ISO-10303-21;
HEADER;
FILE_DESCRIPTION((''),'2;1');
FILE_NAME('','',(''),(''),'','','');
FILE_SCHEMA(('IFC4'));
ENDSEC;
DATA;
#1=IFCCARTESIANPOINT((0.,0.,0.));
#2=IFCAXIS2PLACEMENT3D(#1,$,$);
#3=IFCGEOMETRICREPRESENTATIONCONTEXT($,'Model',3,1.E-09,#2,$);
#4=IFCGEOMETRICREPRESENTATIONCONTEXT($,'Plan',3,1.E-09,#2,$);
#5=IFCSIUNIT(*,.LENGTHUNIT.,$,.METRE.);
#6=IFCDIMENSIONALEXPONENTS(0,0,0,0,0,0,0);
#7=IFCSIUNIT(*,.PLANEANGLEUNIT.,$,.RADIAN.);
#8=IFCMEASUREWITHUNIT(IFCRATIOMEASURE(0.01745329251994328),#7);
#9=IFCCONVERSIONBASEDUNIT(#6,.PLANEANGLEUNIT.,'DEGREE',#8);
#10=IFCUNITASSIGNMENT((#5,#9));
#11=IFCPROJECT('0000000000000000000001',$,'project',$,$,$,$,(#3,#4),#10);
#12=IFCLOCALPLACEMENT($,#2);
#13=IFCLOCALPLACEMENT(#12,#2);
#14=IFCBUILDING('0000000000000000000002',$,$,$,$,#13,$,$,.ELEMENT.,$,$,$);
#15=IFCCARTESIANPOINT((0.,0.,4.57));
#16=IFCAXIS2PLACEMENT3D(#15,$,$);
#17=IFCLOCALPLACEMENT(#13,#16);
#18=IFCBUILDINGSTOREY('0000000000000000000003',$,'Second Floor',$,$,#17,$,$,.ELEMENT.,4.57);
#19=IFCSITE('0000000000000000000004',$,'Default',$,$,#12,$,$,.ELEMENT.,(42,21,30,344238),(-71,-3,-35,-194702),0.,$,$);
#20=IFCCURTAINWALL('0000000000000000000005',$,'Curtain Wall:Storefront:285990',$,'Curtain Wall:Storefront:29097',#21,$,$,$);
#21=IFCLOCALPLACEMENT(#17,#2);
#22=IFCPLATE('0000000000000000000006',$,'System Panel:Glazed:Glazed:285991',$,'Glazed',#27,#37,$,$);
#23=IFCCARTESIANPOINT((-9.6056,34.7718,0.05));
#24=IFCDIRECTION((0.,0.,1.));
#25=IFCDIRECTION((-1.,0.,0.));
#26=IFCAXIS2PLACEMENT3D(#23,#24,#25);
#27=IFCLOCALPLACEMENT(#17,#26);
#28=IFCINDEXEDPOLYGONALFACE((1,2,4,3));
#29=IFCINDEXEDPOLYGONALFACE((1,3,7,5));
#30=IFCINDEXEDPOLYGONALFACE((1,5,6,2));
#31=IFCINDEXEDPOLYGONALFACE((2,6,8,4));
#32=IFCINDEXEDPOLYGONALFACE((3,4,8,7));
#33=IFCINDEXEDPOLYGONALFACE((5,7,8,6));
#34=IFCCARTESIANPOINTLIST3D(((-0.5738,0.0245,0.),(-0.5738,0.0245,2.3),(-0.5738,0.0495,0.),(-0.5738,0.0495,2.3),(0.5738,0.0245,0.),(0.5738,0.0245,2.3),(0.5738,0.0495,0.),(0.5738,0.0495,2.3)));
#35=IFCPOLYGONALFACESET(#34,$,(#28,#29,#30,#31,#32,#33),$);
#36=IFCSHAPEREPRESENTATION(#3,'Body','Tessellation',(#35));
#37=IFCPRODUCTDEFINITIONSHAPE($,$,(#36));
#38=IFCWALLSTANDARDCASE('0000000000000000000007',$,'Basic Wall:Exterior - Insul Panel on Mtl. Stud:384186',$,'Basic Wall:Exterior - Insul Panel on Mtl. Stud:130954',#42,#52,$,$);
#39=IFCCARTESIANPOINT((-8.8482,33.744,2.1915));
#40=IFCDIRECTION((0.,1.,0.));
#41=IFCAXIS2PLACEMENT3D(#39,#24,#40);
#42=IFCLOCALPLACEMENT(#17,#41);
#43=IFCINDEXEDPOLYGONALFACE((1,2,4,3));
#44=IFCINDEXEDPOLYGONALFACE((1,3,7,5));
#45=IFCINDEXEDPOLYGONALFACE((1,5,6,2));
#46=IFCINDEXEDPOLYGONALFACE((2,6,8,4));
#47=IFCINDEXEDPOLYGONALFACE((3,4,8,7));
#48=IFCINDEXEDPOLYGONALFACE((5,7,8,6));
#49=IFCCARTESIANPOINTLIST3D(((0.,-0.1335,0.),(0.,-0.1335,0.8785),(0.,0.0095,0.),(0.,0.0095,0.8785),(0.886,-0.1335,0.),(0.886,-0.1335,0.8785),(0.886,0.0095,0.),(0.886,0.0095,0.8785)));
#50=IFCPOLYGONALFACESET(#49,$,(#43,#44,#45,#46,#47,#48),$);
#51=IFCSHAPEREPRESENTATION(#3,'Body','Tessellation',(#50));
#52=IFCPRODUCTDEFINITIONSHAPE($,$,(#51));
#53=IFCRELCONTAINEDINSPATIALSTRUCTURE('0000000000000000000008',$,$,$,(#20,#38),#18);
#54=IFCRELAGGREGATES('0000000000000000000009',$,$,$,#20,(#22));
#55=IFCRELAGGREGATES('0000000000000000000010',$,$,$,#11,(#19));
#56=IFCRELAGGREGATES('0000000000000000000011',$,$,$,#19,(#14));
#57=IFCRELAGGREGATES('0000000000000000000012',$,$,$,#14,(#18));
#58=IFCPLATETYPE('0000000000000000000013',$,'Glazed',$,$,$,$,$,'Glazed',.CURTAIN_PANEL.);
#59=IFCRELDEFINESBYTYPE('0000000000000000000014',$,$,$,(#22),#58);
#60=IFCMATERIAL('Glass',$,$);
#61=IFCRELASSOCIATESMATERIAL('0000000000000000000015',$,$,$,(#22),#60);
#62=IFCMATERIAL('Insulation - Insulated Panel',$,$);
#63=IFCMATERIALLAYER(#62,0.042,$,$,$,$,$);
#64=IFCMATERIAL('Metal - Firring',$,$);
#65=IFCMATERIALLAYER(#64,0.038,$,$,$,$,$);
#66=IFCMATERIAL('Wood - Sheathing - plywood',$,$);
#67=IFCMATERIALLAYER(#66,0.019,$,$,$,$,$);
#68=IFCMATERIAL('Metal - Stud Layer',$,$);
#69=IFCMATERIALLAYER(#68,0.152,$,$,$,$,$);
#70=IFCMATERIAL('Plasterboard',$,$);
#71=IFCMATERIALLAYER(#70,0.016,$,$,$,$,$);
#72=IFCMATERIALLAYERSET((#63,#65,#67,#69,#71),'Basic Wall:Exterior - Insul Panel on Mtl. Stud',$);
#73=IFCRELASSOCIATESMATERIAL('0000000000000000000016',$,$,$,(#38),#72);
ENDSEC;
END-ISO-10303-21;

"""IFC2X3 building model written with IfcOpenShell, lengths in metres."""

from ifc_helpers import new_model, entity, si_unit, converted_unit, frame, frame_2d, origin, origin_2d_with_axis, place, context, project, spatial, polyline, rectangle, extrude, clip, bounded_halfspace, source, transform, mapped, material, layer, layer_set, layer_usage, type_object, type_shapes, element, aggregate, save


model = new_model("IFC2X3")

# Units and contexts
model_context = context("Model", 3, precision=1e-09, world=origin())
plan_context = context("Plan", 3, precision=1e-09, world=origin())
ifc_project = project(units=[si_unit("LENGTHUNIT", "METRE"), converted_unit("PLANEANGLEUNIT", "DEGREE", entity("IfcRatioMeasure", 0.01745329251994328), si_unit("PLANEANGLEUNIT", "RADIAN"), dimensions=[0, 0, 0, 0, 0, 0, 0])], contexts=[model_context, plan_context])

# Site, building, storey
site_placement = place(None, origin())
site = spatial("IfcSite", under=ifc_project, at=site_placement, Name="Default", CompositionType="ELEMENT", RefLatitude=(42, 21, 30, 344238), RefLongitude=(-71, -3, -35, -194702), RefElevation=0.0)
building_placement = place(site_placement, origin())
building = spatial("IfcBuilding", under=site, at=building_placement, CompositionType="ELEMENT")
storey_placement = place(building_placement, frame((0.0, 0.0, 4.57)))
storey = spatial("IfcBuildingStorey", under=building, at=storey_placement, Name="Second Floor", CompositionType="ELEMENT", Elevation=4.57)

# Curtain wall
curtain_wall_1_placement = place(storey_placement, origin())
curtain_wall_1 = element("IfcCurtainWall", 1, at=curtain_wall_1_placement, inside=storey, Name="Curtain Wall:Storefront:285990", ObjectType="Curtain Wall:Storefront:29097")

# Plate
ifc_material_1 = material(Name="Glass")
plate_type_1 = type_object("IfcPlateType", Name="Glazed", ElementType="Glazed", PredefinedType="CURTAIN_PANEL")
shared_shape_1 = source(origin(), model_context, "Body", "SweptSolid", [
    extrude(rectangle(XDim=0.025, YDim=1.1477, at=origin_2d_with_axis()), frame((0.0, 0.037, 0.0), z_axis=(0.0, 0.0, 1.0), x_axis=(0.0, 1.0, 0.0)), (0.0, 0.0, 1.0), 2.3),
])
type_shapes(plate_type_1, [shared_shape_1])
plate_1_placement = place(storey_placement, frame((-9.6056, 34.7718, 0.05), z_axis=(0.0, 0.0, 1.0), x_axis=(-1.0, 0.0, 0.0)))
plate_1 = element("IfcPlate", 2, at=plate_1_placement, type_object=plate_type_1, material=ifc_material_1, Name="System Panel:Glazed:Glazed:285991", ObjectType="Glazed", context=model_context, shape_type="MappedRepresentation", body=[
    mapped(shared_shape_1, transform((0.0, 0.0, 0.0), scale=1.0)),
])
aggregate(curtain_wall_1, [plate_1])

# Shared definitions
ifc_material_2 = material(Name="Plasterboard")
ifc_layer_1 = layer(ifc_material_2, 0.016)
ifc_material_3 = material(Name="Metal - Stud Layer")
ifc_material_4 = material(Name="Insulation - Insulated Panel")
ifc_layer_2 = layer(ifc_material_4, 0.042)
ifc_material_5 = material(Name="Metal - Firring")
ifc_layer_3 = layer(ifc_material_5, 0.038)
ifc_material_6 = material(Name="Wood - Sheathing - plywood")
ifc_layer_4 = layer(ifc_material_6, 0.019)
ifc_layer_5 = layer(ifc_material_3, 0.152)
ifc_layer_set_1 = layer_set([ifc_layer_2, ifc_layer_3, ifc_layer_4, ifc_layer_5, ifc_layer_1], Name="Basic Wall:Exterior - Insul Panel on Mtl. Stud")

# Wall
ifc_layer_usage_1 = layer_usage(ifc_layer_set_1, "AXIS2", "POSITIVE", -0.1335)
wall_1_placement = place(storey_placement, frame((-8.8482, 33.744, 2.1915), z_axis=(0.0, 0.0, 1.0), x_axis=(0.0, 1.0, 0.0)))
element("IfcWallStandardCase", 3, at=wall_1_placement, inside=storey, material=ifc_layer_usage_1, Name="Basic Wall:Exterior - Insul Panel on Mtl. Stud:384186", ObjectType="Basic Wall:Exterior - Insul Panel on Mtl. Stud:130954", context=model_context, shape_type="Clipping", body=[
    clip(extrude(rectangle(XDim=0.886, YDim=0.267, at=frame_2d((0.443, 0.0), x_axis=(-1.0, 0.0))), origin(), (0.0, 0.0, 1.0), 0.8785), bounded_halfspace(frame((0.886, 0.0095, 0.0), z_axis=(0.0, -1.0, 0.0), x_axis=(1.0, 0.0, 0.0)), True, frame((0.886, 0.0095, 0.0), z_axis=(0.0, -1.0, 0.0), x_axis=(1.0, 0.0, 0.0)), polyline([(0.0, 0.0), (0.0, 0.8785), (-0.4928, 0.8785), (-0.886, 0.8785), (-0.886, 0.0), (0.0, 0.0)]))),
])

save(model, "model.ifc")
